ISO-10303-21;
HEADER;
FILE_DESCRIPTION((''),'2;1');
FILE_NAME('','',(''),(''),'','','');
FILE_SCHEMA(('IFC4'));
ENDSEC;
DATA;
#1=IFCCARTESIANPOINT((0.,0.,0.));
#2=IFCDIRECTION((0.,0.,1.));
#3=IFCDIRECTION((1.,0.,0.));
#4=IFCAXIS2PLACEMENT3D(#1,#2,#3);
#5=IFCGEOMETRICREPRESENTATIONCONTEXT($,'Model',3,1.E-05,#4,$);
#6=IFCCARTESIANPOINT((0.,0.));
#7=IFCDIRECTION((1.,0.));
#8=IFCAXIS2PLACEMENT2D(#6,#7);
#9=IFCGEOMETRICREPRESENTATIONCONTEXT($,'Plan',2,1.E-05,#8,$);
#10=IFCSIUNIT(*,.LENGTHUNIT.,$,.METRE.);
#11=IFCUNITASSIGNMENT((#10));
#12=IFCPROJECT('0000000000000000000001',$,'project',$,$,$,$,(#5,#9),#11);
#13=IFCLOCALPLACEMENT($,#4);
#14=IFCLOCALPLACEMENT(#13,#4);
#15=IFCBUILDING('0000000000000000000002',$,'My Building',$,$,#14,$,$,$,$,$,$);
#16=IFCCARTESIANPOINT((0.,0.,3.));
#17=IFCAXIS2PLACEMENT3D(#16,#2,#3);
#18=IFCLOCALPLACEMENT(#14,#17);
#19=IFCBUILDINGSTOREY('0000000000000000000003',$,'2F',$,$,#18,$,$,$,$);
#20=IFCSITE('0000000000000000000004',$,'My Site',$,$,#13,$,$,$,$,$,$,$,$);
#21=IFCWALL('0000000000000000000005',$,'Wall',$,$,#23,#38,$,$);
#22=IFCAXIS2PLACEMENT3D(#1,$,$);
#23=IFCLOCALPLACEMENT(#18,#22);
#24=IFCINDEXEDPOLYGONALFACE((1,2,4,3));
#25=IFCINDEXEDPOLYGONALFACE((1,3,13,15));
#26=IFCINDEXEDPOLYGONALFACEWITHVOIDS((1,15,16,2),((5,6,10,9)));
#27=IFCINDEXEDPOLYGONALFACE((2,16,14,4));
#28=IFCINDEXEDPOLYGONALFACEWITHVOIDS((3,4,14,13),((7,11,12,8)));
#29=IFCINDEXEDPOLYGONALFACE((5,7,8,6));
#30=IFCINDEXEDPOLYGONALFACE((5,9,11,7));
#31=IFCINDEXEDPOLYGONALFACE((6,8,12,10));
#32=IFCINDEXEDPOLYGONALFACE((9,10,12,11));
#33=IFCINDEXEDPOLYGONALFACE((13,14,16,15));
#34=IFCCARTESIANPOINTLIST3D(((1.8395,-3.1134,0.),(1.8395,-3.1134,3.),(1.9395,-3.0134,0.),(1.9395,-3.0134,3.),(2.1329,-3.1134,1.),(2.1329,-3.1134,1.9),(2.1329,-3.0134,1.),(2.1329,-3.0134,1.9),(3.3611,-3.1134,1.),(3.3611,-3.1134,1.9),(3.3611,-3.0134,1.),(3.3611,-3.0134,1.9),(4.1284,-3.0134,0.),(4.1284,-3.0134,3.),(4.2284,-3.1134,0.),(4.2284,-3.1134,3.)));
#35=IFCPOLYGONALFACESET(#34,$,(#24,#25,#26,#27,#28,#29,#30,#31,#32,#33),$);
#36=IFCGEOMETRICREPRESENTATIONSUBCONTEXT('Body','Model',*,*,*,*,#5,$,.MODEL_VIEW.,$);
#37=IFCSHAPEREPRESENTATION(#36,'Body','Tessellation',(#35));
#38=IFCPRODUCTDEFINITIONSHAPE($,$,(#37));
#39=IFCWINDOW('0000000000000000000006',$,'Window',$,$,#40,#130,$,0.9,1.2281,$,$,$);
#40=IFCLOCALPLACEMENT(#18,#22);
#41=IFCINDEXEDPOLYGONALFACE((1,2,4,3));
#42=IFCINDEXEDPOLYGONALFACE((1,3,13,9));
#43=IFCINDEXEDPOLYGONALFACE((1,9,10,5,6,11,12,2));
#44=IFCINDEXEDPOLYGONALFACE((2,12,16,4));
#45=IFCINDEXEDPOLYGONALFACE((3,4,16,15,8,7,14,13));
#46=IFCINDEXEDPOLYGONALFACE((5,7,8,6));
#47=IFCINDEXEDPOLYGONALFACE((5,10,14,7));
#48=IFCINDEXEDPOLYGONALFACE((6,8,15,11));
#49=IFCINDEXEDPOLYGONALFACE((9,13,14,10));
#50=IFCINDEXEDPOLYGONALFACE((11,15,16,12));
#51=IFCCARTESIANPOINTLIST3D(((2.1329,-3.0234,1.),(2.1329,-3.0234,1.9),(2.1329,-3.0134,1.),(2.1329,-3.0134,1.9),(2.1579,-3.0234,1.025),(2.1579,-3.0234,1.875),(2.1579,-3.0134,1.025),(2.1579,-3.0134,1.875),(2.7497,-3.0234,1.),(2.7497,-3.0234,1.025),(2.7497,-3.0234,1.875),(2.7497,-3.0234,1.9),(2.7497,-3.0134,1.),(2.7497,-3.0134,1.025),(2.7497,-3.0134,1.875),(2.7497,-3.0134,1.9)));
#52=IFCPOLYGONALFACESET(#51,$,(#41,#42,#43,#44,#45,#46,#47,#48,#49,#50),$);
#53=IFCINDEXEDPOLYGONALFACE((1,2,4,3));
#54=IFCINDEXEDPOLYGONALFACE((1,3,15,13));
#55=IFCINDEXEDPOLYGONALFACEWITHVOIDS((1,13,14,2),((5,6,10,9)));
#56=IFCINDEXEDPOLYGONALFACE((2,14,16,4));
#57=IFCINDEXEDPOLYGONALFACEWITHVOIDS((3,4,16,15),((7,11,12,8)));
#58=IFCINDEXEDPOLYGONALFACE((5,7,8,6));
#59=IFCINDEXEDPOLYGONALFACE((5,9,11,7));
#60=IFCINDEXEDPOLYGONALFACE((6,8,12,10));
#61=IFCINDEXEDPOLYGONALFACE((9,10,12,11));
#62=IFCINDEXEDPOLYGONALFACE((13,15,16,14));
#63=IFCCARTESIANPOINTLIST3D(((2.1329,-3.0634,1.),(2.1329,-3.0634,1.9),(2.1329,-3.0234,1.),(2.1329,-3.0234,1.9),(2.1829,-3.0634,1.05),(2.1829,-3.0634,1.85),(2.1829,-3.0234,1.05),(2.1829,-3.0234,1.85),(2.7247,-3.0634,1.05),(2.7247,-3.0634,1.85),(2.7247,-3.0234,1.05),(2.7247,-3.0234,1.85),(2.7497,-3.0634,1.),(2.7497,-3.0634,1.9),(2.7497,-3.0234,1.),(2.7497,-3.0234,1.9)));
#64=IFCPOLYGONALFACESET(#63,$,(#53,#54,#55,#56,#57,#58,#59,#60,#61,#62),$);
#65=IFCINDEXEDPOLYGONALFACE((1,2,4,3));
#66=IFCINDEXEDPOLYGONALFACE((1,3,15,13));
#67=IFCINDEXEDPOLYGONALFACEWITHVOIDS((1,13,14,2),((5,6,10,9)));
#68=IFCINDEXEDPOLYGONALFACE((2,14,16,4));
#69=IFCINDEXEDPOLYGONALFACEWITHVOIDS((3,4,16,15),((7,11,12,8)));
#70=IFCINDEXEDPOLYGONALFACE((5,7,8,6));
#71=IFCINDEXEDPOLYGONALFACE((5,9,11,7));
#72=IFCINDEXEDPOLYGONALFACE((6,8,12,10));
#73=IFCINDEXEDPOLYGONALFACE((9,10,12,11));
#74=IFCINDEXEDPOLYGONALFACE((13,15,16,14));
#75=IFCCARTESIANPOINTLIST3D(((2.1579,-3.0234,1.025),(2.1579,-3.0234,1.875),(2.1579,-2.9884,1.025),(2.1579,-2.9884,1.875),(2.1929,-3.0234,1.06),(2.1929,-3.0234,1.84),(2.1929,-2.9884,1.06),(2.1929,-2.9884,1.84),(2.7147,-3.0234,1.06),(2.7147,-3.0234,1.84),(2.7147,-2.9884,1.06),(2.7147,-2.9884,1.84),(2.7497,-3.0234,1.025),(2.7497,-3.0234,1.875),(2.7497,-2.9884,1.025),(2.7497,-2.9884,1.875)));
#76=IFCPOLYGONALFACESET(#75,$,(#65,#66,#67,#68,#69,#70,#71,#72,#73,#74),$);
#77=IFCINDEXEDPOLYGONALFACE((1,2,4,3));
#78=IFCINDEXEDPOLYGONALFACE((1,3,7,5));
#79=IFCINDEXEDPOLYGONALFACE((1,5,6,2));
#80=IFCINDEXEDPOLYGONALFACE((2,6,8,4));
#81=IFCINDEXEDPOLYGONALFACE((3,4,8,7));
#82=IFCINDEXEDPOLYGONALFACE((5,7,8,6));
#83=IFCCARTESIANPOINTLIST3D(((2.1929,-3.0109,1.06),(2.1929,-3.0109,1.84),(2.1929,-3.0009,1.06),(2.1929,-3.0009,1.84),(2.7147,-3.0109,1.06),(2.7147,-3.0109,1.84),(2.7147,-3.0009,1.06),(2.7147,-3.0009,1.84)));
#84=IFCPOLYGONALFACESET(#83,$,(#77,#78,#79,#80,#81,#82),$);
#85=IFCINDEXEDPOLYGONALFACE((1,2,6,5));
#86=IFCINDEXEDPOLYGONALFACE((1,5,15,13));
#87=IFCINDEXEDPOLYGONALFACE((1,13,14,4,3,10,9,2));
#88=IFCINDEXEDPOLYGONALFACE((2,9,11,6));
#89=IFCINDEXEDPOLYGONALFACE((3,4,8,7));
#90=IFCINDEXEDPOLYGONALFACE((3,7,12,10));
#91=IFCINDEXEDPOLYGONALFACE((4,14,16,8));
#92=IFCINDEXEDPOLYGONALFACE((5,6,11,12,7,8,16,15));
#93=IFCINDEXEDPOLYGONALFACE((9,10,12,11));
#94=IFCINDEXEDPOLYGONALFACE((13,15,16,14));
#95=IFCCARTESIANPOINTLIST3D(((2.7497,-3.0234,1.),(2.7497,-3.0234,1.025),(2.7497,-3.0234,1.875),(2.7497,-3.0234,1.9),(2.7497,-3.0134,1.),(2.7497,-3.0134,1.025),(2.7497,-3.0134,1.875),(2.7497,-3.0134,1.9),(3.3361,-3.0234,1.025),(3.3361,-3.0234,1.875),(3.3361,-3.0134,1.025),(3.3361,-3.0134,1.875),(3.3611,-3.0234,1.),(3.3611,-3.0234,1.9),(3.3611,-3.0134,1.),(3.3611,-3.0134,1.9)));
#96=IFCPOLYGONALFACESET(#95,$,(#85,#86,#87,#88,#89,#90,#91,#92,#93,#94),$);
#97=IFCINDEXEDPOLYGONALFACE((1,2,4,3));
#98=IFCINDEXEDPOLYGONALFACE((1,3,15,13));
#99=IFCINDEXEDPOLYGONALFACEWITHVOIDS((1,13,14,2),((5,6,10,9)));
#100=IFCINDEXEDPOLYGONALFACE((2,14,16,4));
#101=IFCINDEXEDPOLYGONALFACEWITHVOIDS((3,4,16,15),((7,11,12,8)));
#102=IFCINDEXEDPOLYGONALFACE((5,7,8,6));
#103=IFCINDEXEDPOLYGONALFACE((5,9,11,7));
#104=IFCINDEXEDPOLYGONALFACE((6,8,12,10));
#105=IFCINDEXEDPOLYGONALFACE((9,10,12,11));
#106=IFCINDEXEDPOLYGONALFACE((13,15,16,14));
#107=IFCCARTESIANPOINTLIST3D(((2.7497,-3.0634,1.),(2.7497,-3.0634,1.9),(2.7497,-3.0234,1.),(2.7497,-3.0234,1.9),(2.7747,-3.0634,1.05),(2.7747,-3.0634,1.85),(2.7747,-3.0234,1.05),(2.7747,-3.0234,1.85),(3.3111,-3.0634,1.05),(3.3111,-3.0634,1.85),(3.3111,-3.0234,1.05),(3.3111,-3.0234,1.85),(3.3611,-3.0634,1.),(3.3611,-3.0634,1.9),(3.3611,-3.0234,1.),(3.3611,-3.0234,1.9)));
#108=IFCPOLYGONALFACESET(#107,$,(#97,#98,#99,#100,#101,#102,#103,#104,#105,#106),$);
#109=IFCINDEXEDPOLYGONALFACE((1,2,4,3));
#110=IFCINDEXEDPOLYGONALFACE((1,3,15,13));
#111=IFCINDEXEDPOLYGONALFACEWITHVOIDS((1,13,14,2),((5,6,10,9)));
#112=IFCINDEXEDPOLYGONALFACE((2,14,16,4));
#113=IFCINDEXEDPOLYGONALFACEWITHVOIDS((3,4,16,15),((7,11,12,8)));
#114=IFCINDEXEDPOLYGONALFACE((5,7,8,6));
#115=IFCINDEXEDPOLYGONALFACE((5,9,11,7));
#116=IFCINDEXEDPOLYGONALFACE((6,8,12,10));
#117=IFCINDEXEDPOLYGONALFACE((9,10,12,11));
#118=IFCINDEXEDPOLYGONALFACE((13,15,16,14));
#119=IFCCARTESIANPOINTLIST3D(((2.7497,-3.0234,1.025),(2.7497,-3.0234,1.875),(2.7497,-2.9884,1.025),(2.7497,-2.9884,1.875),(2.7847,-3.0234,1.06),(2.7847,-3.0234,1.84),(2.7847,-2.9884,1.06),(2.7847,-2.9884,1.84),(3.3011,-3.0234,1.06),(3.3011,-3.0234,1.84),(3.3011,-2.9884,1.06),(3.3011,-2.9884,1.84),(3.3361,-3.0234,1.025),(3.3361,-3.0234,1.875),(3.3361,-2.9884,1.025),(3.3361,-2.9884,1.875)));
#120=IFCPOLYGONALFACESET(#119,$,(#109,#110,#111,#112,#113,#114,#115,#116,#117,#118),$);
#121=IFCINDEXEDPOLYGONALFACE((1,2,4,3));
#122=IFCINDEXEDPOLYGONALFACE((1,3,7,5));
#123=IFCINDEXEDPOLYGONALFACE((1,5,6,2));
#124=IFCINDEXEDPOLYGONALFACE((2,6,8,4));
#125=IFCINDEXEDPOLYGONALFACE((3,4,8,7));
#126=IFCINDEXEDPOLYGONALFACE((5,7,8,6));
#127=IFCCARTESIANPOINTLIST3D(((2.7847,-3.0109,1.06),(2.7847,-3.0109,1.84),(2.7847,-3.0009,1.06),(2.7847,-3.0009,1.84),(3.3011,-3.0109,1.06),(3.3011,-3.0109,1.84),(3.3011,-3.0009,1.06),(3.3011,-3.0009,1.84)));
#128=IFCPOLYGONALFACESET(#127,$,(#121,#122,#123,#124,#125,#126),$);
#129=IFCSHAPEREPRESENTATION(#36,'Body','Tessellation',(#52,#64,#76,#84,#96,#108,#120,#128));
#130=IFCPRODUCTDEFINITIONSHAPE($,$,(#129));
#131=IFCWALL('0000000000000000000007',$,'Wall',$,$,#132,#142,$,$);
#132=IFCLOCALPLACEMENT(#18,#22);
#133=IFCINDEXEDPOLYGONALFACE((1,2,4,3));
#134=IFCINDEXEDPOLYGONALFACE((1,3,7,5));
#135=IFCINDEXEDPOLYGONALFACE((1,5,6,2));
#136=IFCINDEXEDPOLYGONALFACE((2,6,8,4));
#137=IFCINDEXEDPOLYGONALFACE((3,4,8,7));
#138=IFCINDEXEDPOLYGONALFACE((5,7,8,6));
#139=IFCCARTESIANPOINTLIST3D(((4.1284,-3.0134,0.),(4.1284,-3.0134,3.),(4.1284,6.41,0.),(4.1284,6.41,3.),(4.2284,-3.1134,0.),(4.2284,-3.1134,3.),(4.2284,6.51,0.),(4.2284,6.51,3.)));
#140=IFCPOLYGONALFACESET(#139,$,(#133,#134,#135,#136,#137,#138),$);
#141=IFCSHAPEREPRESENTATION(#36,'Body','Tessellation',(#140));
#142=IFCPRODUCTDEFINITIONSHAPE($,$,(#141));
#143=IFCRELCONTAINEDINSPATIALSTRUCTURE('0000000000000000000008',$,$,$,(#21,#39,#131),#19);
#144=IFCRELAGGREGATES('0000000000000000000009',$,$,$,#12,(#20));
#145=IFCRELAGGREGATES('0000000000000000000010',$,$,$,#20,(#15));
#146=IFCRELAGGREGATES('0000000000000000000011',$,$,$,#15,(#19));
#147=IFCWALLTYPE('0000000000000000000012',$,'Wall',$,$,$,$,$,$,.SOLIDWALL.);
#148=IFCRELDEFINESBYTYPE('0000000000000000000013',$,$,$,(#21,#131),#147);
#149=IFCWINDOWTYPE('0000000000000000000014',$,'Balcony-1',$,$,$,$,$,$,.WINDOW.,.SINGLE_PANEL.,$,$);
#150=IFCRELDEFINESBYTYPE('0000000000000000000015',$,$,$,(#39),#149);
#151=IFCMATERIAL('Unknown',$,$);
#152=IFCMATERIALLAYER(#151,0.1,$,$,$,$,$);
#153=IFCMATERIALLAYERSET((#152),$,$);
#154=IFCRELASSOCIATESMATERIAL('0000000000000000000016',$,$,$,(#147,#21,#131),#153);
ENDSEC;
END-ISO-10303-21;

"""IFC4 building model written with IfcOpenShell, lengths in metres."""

from ifc_helpers import new_model, entity, si_unit, frame, origin_with_axes, origin_2d_with_axis, place, context, subcontext, project, spatial, line, indexed_curve, outline, extrude, shape, source, transform, mapped, material, layer, layer_set, layer_usage, type_object, type_shapes, element, fill, save


model = new_model("IFC4")

# Units and contexts
model_context_1 = context("Model", 3, precision=1e-05, world=origin_with_axes())
plan_context = context("Plan", 2, precision=1e-05, world=origin_2d_with_axis())
body_context_1 = subcontext(model_context_1, "Body", "Model", "MODEL_VIEW")
body_context_2 = subcontext(plan_context, "Body", "Plan", "PLAN_VIEW")
ifc_project = project(units=[si_unit("LENGTHUNIT", "METRE")], contexts=[model_context_1, plan_context])

# Site, building, storey
site_placement = place(None, origin_with_axes())
site = spatial("IfcSite", under=ifc_project, at=site_placement, Name="My Site")
building_placement = place(site_placement, origin_with_axes())
building = spatial("IfcBuilding", under=site, at=building_placement, Name="My Building")
storey_placement = place(building_placement, frame((0.0, 0.0, 3.0), z_axis=(0.0, 0.0, 1.0), x_axis=(1.0, 0.0, 0.0)))
storey = spatial("IfcBuildingStorey", under=building, at=storey_placement, Name="2F")

# Shared definitions
ifc_material = material(Name="Unknown")

# Shared definitions
ifc_layer_1 = layer(ifc_material, 0.1)
ifc_layer_set_1 = layer_set([ifc_layer_1])
wall_type = type_object("IfcWallType", Name="Wall", PredefinedType="SOLIDWALL", material=ifc_layer_set_1)

# Wall, opening, window
ifc_layer_usage_1 = layer_usage(ifc_layer_set_1, "AXIS2", "POSITIVE", 0.0)
wall_1_placement = place(storey_placement, frame((1.8395, -3.1134, 0.0), z_axis=(0.0, 0.0, 1.0), x_axis=(1.0, 0.0, 0.0)))
wall_1 = element("IfcWall", 1, at=wall_1_placement, inside=storey, type_object=wall_type, material=ifc_layer_usage_1, Name="Wall", context=body_context_1, shape_type="SweptSolid", body=[
    extrude(outline(indexed_curve([(0.0, 0.0), (0.1, 0.1), (2.2889, 0.1), (2.3889, 0.0)], segments=[line(1, 2, 3, 4, 1)])), origin_with_axes(), (0.0, 0.0, 1.0), 3.0),
])
shared_shape_1 = source(origin_with_axes(), body_context_1, "Body", "SweptSolid", [
    extrude(outline(indexed_curve([(0.0, 0.0), (1.2281, 0.0), (1.2281, 0.9), (0.0, 0.9)], segments=[line(1, 2, 3, 4, 1)])), frame((0.0, -0.6, 0.0), z_axis=(0.0, -1.0, 0.0), x_axis=(1.0, 0.0, 0.0)), (0.0, 0.0, -1.0), 1.2),
])
opening_1_placement = place(wall_1_placement, frame((0.2934, 0.0, 1.0), z_axis=(0.0, 0.0, 1.0), x_axis=(1.0, 0.0, 0.0)))
opening_1 = element("IfcOpeningElement", 2, at=opening_1_placement, cuts=wall_1, PredefinedType="OPENING", context=body_context_1, shape_type="MappedRepresentation", body=[
    mapped(shared_shape_1, transform((0.0, 0.0, 0.0), x_axis=(1.0, 0.0, 0.0), y_axis=(0.0, 1.0, 0.0), z_axis=(0.0, 0.0, 1.0), scale=1.0)),
])
window_type_1 = type_object("IfcWindowType", Name="Balcony-1", PartitioningType="SINGLE_PANEL", PredefinedType="WINDOW")
shared_shape_2 = source(origin_with_axes(), body_context_1, "Body", "SweptSolid", [
    extrude(outline(indexed_curve([(0.6167, 0.0), (0.0, 0.0), (0.0, 0.9), (0.6167, 0.9), (0.6167, 0.875), (0.025, 0.875), (0.025, 0.025), (0.6167, 0.025)], segments=[line(1, 2, 3, 4, 5, 6, 7, 8, 1)])), frame((0.0, 0.09, 0.0), z_axis=(0.0, -1.0, 0.0), x_axis=(1.0, 0.0, 0.0)), (0.0, 0.0, -1.0), 0.01),
    extrude(outline(indexed_curve([(0.0, 0.0), (0.6167, 0.0), (0.6167, 0.9), (0.0, 0.9)], segments=[line(1, 2, 3, 4, 1)]), holes=[indexed_curve([(0.05, 0.05), (0.5917, 0.05), (0.5917, 0.85), (0.05, 0.85)], segments=[line(1, 2, 3, 4, 1)])]), frame((0.0, 0.05, 0.0), z_axis=(0.0, -1.0, 0.0), x_axis=(1.0, 0.0, 0.0)), (0.0, 0.0, -1.0), 0.04),
    extrude(outline(indexed_curve([(0.0, 0.0), (0.5917, 0.0), (0.5917, 0.85), (0.0, 0.85)], segments=[line(1, 2, 3, 4, 1)]), holes=[indexed_curve([(0.035, 0.035), (0.5567, 0.035), (0.5567, 0.815), (0.035, 0.815)], segments=[line(1, 2, 3, 4, 1)])]), frame((0.025, 0.09, 0.025), z_axis=(0.0, -1.0, 0.0), x_axis=(1.0, 0.0, 0.0)), (0.0, 0.0, -1.0), 0.035),
    extrude(outline(indexed_curve([(0.035, 0.035), (0.5567, 0.035), (0.5567, 0.815), (0.035, 0.815)], segments=[line(1, 2, 3, 4, 1)])), frame((0.025, 0.1025, 0.025), z_axis=(0.0, -1.0, 0.0), x_axis=(1.0, 0.0, 0.0)), (0.0, 0.0, -1.0), 0.01),
    extrude(outline(indexed_curve([(0.0, 0.9), (0.6114, 0.9), (0.6114, 0.0), (0.0, 0.0), (0.0, 0.025), (0.5864, 0.025), (0.5864, 0.875), (0.0, 0.875)], segments=[line(1, 2, 3, 4, 5, 6, 7, 8, 1)])), frame((0.6167, 0.09, 0.0), z_axis=(0.0, -1.0, 0.0), x_axis=(1.0, 0.0, 0.0)), (0.0, 0.0, -1.0), 0.01),
    extrude(outline(indexed_curve([(0.0, 0.0), (0.6114, 0.0), (0.6114, 0.9), (0.0, 0.9)], segments=[line(1, 2, 3, 4, 1)]), holes=[indexed_curve([(0.025, 0.05), (0.5614, 0.05), (0.5614, 0.85), (0.025, 0.85)], segments=[line(1, 2, 3, 4, 1)])]), frame((0.6167, 0.05, 0.0), z_axis=(0.0, -1.0, 0.0), x_axis=(1.0, 0.0, 0.0)), (0.0, 0.0, -1.0), 0.04),
    extrude(outline(indexed_curve([(0.0, 0.0), (0.5864, 0.0), (0.5864, 0.85), (0.0, 0.85)], segments=[line(1, 2, 3, 4, 1)]), holes=[indexed_curve([(0.035, 0.035), (0.5514, 0.035), (0.5514, 0.815), (0.035, 0.815)], segments=[line(1, 2, 3, 4, 1)])]), frame((0.6167, 0.09, 0.025), z_axis=(0.0, -1.0, 0.0), x_axis=(1.0, 0.0, 0.0)), (0.0, 0.0, -1.0), 0.035),
    extrude(outline(indexed_curve([(0.035, 0.035), (0.5514, 0.035), (0.5514, 0.815), (0.035, 0.815)], segments=[line(1, 2, 3, 4, 1)])), frame((0.6167, 0.1025, 0.025), z_axis=(0.0, -1.0, 0.0), x_axis=(1.0, 0.0, 0.0)), (0.0, 0.0, -1.0), 0.01),
])
shared_shape_3 = source(origin_with_axes(), body_context_2, "Body", "Curve2D", [
    entity("IfcIndexedPolyCurve", entity("IfcCartesianPointList2D", [[0.05, 0.05], [0.5917, 0.05]])),
    entity("IfcIndexedPolyCurve", entity("IfcCartesianPointList2D", [[0.0, 0.1], [0.025, 0.1], [0.025, 0.09], [0.05, 0.09], [0.05, 0.05], [0.0, 0.05]]), [entity("IfcLineIndex", [1, 2, 3, 4, 5, 6, 1])]),
    entity("IfcIndexedPolyCurve", entity("IfcCartesianPointList2D", [[0.6167, 0.1], [0.6167, 0.1], [0.6167, 0.09], [0.5917, 0.09], [0.5917, 0.05], [0.6167, 0.05]])),
    entity("IfcIndexedPolyCurve", entity("IfcCartesianPointList2D", [[0.025, 0.09], [0.06, 0.09], [0.06, 0.125], [0.025, 0.125]]), [entity("IfcLineIndex", [1, 2, 3, 4, 1])]),
    entity("IfcIndexedPolyCurve", entity("IfcCartesianPointList2D", [[0.6167, 0.09], [0.5817, 0.09], [0.5817, 0.125], [0.6167, 0.125]]), [entity("IfcLineIndex", [1, 2, 3, 4, 1])]),
    entity("IfcIndexedPolyCurve", entity("IfcCartesianPointList2D", [[0.06, 0.09], [0.5817, 0.09]])),
    entity("IfcIndexedPolyCurve", entity("IfcCartesianPointList2D", [[0.06, 0.125], [0.5817, 0.125]])),
    entity("IfcIndexedPolyCurve", entity("IfcCartesianPointList2D", [[0.06, 0.1075], [0.5817, 0.1075]])),
    entity("IfcIndexedPolyCurve", entity("IfcCartesianPointList2D", [[0.6417, 0.05], [1.1781, 0.05]])),
    entity("IfcIndexedPolyCurve", entity("IfcCartesianPointList2D", [[0.6167, 0.1], [0.6167, 0.1], [0.6167, 0.09], [0.6417, 0.09], [0.6417, 0.05], [0.6167, 0.05]])),
    entity("IfcIndexedPolyCurve", entity("IfcCartesianPointList2D", [[1.2281, 0.1], [1.2031, 0.1], [1.2031, 0.09], [1.1781, 0.09], [1.1781, 0.05], [1.2281, 0.05]]), [entity("IfcLineIndex", [1, 2, 3, 4, 5, 6, 1])]),
    entity("IfcIndexedPolyCurve", entity("IfcCartesianPointList2D", [[0.6167, 0.09], [0.6517, 0.09], [0.6517, 0.125], [0.6167, 0.125]]), [entity("IfcLineIndex", [1, 2, 3, 4, 1])]),
    entity("IfcIndexedPolyCurve", entity("IfcCartesianPointList2D", [[1.2031, 0.09], [1.1681, 0.09], [1.1681, 0.125], [1.2031, 0.125]]), [entity("IfcLineIndex", [1, 2, 3, 4, 1])]),
    entity("IfcIndexedPolyCurve", entity("IfcCartesianPointList2D", [[0.6517, 0.09], [1.1681, 0.09]])),
    entity("IfcIndexedPolyCurve", entity("IfcCartesianPointList2D", [[0.6517, 0.125], [1.1681, 0.125]])),
    entity("IfcIndexedPolyCurve", entity("IfcCartesianPointList2D", [[0.6517, 0.1075], [1.1681, 0.1075]])),
])
type_shapes(window_type_1, [shared_shape_2, shared_shape_3])
window_1_placement = place(opening_1_placement, frame((0.0, 0.0, 0.0), z_axis=(0.0, 0.0, 1.0), x_axis=(1.0, 0.0, 0.0)))
window_1 = element("IfcWindow", 3, at=window_1_placement, inside=storey, type_object=window_type_1, Name="Window", OverallHeight=0.9, OverallWidth=1.2281, shapes=[
    shape(body_context_1, "Body", "MappedRepresentation", [mapped(shared_shape_2, transform((0.0, 0.0, 0.0), x_axis=(1.0, 0.0, 0.0), y_axis=(0.0, 1.0, 0.0), z_axis=(0.0, 0.0, 1.0), scale=1.0))]),
    shape(body_context_2, "Body", "MappedRepresentation", [mapped(shared_shape_3, transform((0.0, 0.0, 0.0), x_axis=(1.0, 0.0, 0.0), y_axis=(0.0, 1.0, 0.0), z_axis=(0.0, 0.0, 1.0), scale=1.0))]),
])
fill(opening_1, window_1)

# Wall
ifc_layer_usage_2 = layer_usage(ifc_layer_set_1, "AXIS2", "POSITIVE", 0.0)
wall_2_placement = place(storey_placement, frame((4.2284, -3.1134, 0.0), z_axis=(0.0, 0.0, 1.0), x_axis=(0.0, 1.0, 0.0)))
element("IfcWall", 4, at=wall_2_placement, inside=storey, type_object=wall_type, material=ifc_layer_usage_2, Name="Wall", context=body_context_1, shape_type="SweptSolid", body=[
    extrude(outline(indexed_curve([(0.0, 0.0), (0.1, 0.1), (9.5233, 0.1), (9.6233, 0.0)], segments=[line(1, 2, 3, 4, 1)])), origin_with_axes(), (0.0, 0.0, 1.0), 3.0),
])

save(model, "model.ifc")
